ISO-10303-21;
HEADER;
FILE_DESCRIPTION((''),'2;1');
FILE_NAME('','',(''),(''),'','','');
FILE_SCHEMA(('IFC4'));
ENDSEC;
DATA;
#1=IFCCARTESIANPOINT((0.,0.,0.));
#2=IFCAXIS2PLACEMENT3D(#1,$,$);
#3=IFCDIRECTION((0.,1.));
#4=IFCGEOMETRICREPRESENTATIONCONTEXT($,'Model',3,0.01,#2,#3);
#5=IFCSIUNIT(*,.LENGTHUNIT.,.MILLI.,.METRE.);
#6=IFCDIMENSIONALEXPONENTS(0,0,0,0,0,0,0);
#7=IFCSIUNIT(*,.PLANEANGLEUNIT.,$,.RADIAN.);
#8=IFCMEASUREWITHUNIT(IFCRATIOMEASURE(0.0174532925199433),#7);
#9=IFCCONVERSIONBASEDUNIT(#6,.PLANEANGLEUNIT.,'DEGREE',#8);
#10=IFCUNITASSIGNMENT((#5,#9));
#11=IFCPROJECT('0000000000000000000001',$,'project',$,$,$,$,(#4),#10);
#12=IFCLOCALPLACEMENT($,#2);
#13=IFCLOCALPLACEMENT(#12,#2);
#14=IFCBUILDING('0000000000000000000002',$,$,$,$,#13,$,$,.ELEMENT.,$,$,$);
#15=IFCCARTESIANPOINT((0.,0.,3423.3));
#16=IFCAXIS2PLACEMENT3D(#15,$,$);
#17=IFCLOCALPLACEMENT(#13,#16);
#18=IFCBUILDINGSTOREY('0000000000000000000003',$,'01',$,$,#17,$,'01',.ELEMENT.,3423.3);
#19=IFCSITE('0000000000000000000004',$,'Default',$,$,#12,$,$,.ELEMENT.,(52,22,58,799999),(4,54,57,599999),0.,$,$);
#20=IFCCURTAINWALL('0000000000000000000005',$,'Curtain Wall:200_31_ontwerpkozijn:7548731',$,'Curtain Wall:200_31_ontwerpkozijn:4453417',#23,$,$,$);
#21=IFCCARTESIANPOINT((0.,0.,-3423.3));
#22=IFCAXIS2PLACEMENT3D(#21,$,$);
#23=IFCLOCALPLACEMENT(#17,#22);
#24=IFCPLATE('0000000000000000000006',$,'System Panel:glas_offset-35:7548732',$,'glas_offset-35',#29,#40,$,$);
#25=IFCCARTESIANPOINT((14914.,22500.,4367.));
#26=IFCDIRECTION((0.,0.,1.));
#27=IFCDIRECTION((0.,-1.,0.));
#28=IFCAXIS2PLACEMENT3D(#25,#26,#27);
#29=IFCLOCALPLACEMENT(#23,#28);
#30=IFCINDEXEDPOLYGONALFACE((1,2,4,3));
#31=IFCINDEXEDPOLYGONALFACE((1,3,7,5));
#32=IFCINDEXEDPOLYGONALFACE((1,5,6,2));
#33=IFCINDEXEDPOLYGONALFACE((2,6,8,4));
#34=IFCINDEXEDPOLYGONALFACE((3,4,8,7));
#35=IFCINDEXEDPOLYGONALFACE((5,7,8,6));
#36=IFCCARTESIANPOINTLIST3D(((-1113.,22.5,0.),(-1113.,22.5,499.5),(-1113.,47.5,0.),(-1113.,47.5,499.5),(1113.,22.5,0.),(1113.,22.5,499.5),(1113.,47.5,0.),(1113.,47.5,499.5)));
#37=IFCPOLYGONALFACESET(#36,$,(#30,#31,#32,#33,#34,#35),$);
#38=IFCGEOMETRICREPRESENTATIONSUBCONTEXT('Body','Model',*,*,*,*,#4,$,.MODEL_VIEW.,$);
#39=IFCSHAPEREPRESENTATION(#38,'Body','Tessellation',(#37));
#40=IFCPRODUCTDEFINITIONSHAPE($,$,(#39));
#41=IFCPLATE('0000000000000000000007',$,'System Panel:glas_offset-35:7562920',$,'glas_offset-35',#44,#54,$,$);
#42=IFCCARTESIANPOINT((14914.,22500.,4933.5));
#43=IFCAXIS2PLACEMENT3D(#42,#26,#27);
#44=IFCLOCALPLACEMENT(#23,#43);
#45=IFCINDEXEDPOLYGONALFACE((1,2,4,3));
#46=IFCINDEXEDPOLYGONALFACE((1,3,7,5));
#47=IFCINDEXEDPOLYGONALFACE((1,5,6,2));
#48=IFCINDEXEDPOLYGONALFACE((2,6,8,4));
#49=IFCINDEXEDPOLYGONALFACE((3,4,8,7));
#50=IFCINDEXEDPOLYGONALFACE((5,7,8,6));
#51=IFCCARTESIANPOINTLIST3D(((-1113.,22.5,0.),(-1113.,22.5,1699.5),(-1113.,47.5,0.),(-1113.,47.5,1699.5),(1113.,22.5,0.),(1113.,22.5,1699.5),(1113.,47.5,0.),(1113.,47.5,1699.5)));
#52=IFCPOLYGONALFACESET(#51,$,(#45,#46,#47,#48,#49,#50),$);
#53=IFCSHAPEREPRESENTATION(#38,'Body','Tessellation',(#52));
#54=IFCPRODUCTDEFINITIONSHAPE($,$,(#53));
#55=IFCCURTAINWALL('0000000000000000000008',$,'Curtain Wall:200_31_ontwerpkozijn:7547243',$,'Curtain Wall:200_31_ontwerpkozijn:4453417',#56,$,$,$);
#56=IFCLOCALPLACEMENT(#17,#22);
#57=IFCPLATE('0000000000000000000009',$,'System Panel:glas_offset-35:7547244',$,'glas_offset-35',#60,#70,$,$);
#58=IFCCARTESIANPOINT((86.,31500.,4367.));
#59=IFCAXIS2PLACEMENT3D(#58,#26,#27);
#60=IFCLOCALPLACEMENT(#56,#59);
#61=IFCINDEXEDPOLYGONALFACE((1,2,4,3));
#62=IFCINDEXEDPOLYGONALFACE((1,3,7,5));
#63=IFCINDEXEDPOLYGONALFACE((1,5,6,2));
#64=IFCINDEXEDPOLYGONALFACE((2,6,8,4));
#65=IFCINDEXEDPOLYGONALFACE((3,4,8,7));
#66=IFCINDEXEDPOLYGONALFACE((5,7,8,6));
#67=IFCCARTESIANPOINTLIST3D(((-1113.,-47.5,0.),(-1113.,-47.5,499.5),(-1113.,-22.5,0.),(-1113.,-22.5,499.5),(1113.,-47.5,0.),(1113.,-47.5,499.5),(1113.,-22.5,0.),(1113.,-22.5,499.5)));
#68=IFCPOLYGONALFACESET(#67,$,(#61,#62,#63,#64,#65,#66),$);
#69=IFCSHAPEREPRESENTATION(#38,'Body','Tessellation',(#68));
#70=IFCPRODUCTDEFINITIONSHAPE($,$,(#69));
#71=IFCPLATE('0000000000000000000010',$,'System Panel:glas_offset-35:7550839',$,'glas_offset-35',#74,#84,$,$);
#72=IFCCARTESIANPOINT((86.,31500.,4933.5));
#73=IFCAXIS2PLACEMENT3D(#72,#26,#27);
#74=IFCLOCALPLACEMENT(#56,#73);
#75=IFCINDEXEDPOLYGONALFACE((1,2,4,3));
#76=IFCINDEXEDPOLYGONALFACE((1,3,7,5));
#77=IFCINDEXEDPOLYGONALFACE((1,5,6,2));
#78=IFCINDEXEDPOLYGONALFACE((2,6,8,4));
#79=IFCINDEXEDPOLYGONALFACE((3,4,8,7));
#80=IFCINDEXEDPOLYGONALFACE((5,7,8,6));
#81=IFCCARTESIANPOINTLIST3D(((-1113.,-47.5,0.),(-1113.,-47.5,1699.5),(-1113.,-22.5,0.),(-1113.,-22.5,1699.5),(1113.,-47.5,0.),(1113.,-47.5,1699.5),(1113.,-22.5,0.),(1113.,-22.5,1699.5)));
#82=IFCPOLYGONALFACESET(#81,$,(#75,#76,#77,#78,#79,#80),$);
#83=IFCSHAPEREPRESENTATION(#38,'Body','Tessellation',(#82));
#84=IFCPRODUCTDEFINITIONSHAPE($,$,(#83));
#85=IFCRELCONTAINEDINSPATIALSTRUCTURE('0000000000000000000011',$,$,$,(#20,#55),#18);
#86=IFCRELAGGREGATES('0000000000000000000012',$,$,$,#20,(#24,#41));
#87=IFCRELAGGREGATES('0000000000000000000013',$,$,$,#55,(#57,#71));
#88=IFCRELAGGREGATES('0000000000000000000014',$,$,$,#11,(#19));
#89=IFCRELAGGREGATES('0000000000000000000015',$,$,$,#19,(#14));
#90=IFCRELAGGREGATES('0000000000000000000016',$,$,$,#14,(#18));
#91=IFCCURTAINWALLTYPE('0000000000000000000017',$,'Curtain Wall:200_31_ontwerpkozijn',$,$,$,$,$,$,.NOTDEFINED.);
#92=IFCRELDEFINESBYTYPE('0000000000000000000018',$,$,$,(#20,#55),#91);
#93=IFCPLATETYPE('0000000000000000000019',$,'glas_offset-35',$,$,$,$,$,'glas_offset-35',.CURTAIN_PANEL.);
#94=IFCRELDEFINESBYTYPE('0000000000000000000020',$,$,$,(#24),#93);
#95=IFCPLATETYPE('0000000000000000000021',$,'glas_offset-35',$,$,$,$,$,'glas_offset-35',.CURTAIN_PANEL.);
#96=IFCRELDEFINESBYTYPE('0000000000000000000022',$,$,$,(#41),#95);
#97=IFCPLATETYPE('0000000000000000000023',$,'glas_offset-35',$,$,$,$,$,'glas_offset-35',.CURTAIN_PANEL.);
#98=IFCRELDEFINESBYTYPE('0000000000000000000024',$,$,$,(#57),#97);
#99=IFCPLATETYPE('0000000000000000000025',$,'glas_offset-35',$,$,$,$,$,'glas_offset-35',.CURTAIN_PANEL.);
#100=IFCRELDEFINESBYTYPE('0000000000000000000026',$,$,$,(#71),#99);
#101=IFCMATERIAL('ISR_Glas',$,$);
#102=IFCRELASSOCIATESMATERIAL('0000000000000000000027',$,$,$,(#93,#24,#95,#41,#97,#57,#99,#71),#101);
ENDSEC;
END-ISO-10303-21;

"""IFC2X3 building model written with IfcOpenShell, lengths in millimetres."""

from ifc_helpers import new_model, entity, si_unit, converted_unit, direction, frame, frame_2d, origin, origin_2d_with_axis, place, context, subcontext, project, spatial, rectangle, extrude, source, transform, mapped, material, type_object, type_shapes, element, aggregate, save


model = new_model("IFC2X3")

# Units and contexts
model_context = context("Model", 3, precision=0.01, world=origin(), true_north=direction((0.0, 1.0)))
body_context = subcontext(model_context, "Body", "Model", "MODEL_VIEW")
ifc_project = project(units=[si_unit("LENGTHUNIT", "METRE", prefix="MILLI"), converted_unit("PLANEANGLEUNIT", "DEGREE", entity("IfcRatioMeasure", 0.0174532925199433), si_unit("PLANEANGLEUNIT", "RADIAN"), dimensions=[0, 0, 0, 0, 0, 0, 0])], contexts=[model_context])

# Site, building, storey
site_placement = place(None, origin())
site = spatial("IfcSite", under=ifc_project, at=site_placement, Name="Default", CompositionType="ELEMENT", RefLatitude=(52, 22, 58, 799999), RefLongitude=(4, 54, 57, 599999), RefElevation=0.0)
building_placement = place(site_placement, origin())
building = spatial("IfcBuilding", under=site, at=building_placement, CompositionType="ELEMENT")
storey_placement = place(building_placement, frame((0.0, 0.0, 3423.3)))
storey = spatial("IfcBuildingStorey", under=building, at=storey_placement, Name="01", LongName="01", CompositionType="ELEMENT", Elevation=3423.3)

# Curtain walls, plates
curtain_wall_type = type_object("IfcCurtainWallType", Name="Curtain Wall:200_31_ontwerpkozijn", PredefinedType="NOTDEFINED")
curtain_wall_1_placement = place(storey_placement, frame((0.0, 0.0, -3423.3)))
curtain_wall_1 = element("IfcCurtainWall", 1, at=curtain_wall_1_placement, inside=storey, type_object=curtain_wall_type, Name="Curtain Wall:200_31_ontwerpkozijn:7548731", ObjectType="Curtain Wall:200_31_ontwerpkozijn:4453417")
ifc_material_1 = material(Name="ISR_Glas")
plate_type_1 = type_object("IfcPlateType", Name="glas_offset-35", ElementType="glas_offset-35", PredefinedType="CURTAIN_PANEL", material=ifc_material_1)
shared_shape_1 = source(origin(), body_context, "Body", "SweptSolid", [
    extrude(rectangle(XDim=25.0, YDim=2226.0, at=origin_2d_with_axis()), frame((0.0, 35.0, 0.0), z_axis=(0.0, 0.0, 1.0), x_axis=(0.0, 1.0, 0.0)), (0.0, 0.0, 1.0), 499.5),
])
type_shapes(plate_type_1, [shared_shape_1])
plate_1_placement = place(curtain_wall_1_placement, frame((14914.0, 22500.0, 4367.0), z_axis=(0.0, 0.0, 1.0), x_axis=(0.0, -1.0, 0.0)))
plate_1 = element("IfcPlate", 2, at=plate_1_placement, type_object=plate_type_1, material=ifc_material_1, Name="System Panel:glas_offset-35:7548732", ObjectType="glas_offset-35", context=body_context, shape_type="MappedRepresentation", body=[
    mapped(shared_shape_1, transform((0.0, 0.0, 0.0), scale=1.0)),
])
plate_type_2 = type_object("IfcPlateType", Name="glas_offset-35", ElementType="glas_offset-35", PredefinedType="CURTAIN_PANEL", material=ifc_material_1)
shared_shape_2 = source(origin(), body_context, "Body", "SweptSolid", [
    extrude(rectangle(XDim=25.0, YDim=2226.0, at=origin_2d_with_axis()), frame((0.0, 35.0, 0.0), z_axis=(0.0, 0.0, 1.0), x_axis=(0.0, 1.0, 0.0)), (0.0, 0.0, 1.0), 1699.5),
])
type_shapes(plate_type_2, [shared_shape_2])
plate_2_placement = place(curtain_wall_1_placement, frame((14914.0, 22500.0, 4933.5), z_axis=(0.0, 0.0, 1.0), x_axis=(0.0, -1.0, 0.0)))
plate_2 = element("IfcPlate", 3, at=plate_2_placement, type_object=plate_type_2, material=ifc_material_1, Name="System Panel:glas_offset-35:7562920", ObjectType="glas_offset-35", context=body_context, shape_type="MappedRepresentation", body=[
    mapped(shared_shape_2, transform((0.0, 0.0, 0.0), scale=1.0)),
])
aggregate(curtain_wall_1, [plate_1, plate_2])
curtain_wall_2_placement = place(storey_placement, frame((0.0, 0.0, -3423.3)))
curtain_wall_2 = element("IfcCurtainWall", 4, at=curtain_wall_2_placement, inside=storey, type_object=curtain_wall_type, Name="Curtain Wall:200_31_ontwerpkozijn:7547243", ObjectType="Curtain Wall:200_31_ontwerpkozijn:4453417")
plate_type_3 = type_object("IfcPlateType", Name="glas_offset-35", ElementType="glas_offset-35", PredefinedType="CURTAIN_PANEL", material=ifc_material_1)
shared_shape_3 = source(origin(), body_context, "Body", "SweptSolid", [
    extrude(rectangle(XDim=25.0, YDim=2226.0, at=frame_2d((0.0, 0.0), x_axis=(1.0, 0.0))), frame((0.0, -35.0, 0.0), z_axis=(0.0, 0.0, 1.0), x_axis=(0.0, 1.0, 0.0)), (0.0, 0.0, 1.0), 499.5),
])
type_shapes(plate_type_3, [shared_shape_3])
plate_3_placement = place(curtain_wall_2_placement, frame((86.0, 31500.0, 4367.0), z_axis=(0.0, 0.0, 1.0), x_axis=(0.0, -1.0, 0.0)))
plate_3 = element("IfcPlate", 5, at=plate_3_placement, type_object=plate_type_3, material=ifc_material_1, Name="System Panel:glas_offset-35:7547244", ObjectType="glas_offset-35", context=body_context, shape_type="MappedRepresentation", body=[
    mapped(shared_shape_3, transform((0.0, 0.0, 0.0), scale=1.0)),
])
plate_type_4 = type_object("IfcPlateType", Name="glas_offset-35", ElementType="glas_offset-35", PredefinedType="CURTAIN_PANEL", material=ifc_material_1)
shared_shape_4 = source(origin(), body_context, "Body", "SweptSolid", [
    extrude(rectangle(XDim=25.0, YDim=2226.0, at=frame_2d((0.0, 0.0), x_axis=(1.0, 0.0))), frame((0.0, -35.0, 0.0), z_axis=(0.0, 0.0, 1.0), x_axis=(0.0, 1.0, 0.0)), (0.0, 0.0, 1.0), 1699.5),
])
type_shapes(plate_type_4, [shared_shape_4])
plate_4_placement = place(curtain_wall_2_placement, frame((86.0, 31500.0, 4933.5), z_axis=(0.0, 0.0, 1.0), x_axis=(0.0, -1.0, 0.0)))
plate_4 = element("IfcPlate", 6, at=plate_4_placement, type_object=plate_type_4, material=ifc_material_1, Name="System Panel:glas_offset-35:7550839", ObjectType="glas_offset-35", context=body_context, shape_type="MappedRepresentation", body=[
    mapped(shared_shape_4, transform((0.0, 0.0, 0.0), scale=1.0)),
])
aggregate(curtain_wall_2, [plate_3, plate_4])

save(model, "model.ifc")
